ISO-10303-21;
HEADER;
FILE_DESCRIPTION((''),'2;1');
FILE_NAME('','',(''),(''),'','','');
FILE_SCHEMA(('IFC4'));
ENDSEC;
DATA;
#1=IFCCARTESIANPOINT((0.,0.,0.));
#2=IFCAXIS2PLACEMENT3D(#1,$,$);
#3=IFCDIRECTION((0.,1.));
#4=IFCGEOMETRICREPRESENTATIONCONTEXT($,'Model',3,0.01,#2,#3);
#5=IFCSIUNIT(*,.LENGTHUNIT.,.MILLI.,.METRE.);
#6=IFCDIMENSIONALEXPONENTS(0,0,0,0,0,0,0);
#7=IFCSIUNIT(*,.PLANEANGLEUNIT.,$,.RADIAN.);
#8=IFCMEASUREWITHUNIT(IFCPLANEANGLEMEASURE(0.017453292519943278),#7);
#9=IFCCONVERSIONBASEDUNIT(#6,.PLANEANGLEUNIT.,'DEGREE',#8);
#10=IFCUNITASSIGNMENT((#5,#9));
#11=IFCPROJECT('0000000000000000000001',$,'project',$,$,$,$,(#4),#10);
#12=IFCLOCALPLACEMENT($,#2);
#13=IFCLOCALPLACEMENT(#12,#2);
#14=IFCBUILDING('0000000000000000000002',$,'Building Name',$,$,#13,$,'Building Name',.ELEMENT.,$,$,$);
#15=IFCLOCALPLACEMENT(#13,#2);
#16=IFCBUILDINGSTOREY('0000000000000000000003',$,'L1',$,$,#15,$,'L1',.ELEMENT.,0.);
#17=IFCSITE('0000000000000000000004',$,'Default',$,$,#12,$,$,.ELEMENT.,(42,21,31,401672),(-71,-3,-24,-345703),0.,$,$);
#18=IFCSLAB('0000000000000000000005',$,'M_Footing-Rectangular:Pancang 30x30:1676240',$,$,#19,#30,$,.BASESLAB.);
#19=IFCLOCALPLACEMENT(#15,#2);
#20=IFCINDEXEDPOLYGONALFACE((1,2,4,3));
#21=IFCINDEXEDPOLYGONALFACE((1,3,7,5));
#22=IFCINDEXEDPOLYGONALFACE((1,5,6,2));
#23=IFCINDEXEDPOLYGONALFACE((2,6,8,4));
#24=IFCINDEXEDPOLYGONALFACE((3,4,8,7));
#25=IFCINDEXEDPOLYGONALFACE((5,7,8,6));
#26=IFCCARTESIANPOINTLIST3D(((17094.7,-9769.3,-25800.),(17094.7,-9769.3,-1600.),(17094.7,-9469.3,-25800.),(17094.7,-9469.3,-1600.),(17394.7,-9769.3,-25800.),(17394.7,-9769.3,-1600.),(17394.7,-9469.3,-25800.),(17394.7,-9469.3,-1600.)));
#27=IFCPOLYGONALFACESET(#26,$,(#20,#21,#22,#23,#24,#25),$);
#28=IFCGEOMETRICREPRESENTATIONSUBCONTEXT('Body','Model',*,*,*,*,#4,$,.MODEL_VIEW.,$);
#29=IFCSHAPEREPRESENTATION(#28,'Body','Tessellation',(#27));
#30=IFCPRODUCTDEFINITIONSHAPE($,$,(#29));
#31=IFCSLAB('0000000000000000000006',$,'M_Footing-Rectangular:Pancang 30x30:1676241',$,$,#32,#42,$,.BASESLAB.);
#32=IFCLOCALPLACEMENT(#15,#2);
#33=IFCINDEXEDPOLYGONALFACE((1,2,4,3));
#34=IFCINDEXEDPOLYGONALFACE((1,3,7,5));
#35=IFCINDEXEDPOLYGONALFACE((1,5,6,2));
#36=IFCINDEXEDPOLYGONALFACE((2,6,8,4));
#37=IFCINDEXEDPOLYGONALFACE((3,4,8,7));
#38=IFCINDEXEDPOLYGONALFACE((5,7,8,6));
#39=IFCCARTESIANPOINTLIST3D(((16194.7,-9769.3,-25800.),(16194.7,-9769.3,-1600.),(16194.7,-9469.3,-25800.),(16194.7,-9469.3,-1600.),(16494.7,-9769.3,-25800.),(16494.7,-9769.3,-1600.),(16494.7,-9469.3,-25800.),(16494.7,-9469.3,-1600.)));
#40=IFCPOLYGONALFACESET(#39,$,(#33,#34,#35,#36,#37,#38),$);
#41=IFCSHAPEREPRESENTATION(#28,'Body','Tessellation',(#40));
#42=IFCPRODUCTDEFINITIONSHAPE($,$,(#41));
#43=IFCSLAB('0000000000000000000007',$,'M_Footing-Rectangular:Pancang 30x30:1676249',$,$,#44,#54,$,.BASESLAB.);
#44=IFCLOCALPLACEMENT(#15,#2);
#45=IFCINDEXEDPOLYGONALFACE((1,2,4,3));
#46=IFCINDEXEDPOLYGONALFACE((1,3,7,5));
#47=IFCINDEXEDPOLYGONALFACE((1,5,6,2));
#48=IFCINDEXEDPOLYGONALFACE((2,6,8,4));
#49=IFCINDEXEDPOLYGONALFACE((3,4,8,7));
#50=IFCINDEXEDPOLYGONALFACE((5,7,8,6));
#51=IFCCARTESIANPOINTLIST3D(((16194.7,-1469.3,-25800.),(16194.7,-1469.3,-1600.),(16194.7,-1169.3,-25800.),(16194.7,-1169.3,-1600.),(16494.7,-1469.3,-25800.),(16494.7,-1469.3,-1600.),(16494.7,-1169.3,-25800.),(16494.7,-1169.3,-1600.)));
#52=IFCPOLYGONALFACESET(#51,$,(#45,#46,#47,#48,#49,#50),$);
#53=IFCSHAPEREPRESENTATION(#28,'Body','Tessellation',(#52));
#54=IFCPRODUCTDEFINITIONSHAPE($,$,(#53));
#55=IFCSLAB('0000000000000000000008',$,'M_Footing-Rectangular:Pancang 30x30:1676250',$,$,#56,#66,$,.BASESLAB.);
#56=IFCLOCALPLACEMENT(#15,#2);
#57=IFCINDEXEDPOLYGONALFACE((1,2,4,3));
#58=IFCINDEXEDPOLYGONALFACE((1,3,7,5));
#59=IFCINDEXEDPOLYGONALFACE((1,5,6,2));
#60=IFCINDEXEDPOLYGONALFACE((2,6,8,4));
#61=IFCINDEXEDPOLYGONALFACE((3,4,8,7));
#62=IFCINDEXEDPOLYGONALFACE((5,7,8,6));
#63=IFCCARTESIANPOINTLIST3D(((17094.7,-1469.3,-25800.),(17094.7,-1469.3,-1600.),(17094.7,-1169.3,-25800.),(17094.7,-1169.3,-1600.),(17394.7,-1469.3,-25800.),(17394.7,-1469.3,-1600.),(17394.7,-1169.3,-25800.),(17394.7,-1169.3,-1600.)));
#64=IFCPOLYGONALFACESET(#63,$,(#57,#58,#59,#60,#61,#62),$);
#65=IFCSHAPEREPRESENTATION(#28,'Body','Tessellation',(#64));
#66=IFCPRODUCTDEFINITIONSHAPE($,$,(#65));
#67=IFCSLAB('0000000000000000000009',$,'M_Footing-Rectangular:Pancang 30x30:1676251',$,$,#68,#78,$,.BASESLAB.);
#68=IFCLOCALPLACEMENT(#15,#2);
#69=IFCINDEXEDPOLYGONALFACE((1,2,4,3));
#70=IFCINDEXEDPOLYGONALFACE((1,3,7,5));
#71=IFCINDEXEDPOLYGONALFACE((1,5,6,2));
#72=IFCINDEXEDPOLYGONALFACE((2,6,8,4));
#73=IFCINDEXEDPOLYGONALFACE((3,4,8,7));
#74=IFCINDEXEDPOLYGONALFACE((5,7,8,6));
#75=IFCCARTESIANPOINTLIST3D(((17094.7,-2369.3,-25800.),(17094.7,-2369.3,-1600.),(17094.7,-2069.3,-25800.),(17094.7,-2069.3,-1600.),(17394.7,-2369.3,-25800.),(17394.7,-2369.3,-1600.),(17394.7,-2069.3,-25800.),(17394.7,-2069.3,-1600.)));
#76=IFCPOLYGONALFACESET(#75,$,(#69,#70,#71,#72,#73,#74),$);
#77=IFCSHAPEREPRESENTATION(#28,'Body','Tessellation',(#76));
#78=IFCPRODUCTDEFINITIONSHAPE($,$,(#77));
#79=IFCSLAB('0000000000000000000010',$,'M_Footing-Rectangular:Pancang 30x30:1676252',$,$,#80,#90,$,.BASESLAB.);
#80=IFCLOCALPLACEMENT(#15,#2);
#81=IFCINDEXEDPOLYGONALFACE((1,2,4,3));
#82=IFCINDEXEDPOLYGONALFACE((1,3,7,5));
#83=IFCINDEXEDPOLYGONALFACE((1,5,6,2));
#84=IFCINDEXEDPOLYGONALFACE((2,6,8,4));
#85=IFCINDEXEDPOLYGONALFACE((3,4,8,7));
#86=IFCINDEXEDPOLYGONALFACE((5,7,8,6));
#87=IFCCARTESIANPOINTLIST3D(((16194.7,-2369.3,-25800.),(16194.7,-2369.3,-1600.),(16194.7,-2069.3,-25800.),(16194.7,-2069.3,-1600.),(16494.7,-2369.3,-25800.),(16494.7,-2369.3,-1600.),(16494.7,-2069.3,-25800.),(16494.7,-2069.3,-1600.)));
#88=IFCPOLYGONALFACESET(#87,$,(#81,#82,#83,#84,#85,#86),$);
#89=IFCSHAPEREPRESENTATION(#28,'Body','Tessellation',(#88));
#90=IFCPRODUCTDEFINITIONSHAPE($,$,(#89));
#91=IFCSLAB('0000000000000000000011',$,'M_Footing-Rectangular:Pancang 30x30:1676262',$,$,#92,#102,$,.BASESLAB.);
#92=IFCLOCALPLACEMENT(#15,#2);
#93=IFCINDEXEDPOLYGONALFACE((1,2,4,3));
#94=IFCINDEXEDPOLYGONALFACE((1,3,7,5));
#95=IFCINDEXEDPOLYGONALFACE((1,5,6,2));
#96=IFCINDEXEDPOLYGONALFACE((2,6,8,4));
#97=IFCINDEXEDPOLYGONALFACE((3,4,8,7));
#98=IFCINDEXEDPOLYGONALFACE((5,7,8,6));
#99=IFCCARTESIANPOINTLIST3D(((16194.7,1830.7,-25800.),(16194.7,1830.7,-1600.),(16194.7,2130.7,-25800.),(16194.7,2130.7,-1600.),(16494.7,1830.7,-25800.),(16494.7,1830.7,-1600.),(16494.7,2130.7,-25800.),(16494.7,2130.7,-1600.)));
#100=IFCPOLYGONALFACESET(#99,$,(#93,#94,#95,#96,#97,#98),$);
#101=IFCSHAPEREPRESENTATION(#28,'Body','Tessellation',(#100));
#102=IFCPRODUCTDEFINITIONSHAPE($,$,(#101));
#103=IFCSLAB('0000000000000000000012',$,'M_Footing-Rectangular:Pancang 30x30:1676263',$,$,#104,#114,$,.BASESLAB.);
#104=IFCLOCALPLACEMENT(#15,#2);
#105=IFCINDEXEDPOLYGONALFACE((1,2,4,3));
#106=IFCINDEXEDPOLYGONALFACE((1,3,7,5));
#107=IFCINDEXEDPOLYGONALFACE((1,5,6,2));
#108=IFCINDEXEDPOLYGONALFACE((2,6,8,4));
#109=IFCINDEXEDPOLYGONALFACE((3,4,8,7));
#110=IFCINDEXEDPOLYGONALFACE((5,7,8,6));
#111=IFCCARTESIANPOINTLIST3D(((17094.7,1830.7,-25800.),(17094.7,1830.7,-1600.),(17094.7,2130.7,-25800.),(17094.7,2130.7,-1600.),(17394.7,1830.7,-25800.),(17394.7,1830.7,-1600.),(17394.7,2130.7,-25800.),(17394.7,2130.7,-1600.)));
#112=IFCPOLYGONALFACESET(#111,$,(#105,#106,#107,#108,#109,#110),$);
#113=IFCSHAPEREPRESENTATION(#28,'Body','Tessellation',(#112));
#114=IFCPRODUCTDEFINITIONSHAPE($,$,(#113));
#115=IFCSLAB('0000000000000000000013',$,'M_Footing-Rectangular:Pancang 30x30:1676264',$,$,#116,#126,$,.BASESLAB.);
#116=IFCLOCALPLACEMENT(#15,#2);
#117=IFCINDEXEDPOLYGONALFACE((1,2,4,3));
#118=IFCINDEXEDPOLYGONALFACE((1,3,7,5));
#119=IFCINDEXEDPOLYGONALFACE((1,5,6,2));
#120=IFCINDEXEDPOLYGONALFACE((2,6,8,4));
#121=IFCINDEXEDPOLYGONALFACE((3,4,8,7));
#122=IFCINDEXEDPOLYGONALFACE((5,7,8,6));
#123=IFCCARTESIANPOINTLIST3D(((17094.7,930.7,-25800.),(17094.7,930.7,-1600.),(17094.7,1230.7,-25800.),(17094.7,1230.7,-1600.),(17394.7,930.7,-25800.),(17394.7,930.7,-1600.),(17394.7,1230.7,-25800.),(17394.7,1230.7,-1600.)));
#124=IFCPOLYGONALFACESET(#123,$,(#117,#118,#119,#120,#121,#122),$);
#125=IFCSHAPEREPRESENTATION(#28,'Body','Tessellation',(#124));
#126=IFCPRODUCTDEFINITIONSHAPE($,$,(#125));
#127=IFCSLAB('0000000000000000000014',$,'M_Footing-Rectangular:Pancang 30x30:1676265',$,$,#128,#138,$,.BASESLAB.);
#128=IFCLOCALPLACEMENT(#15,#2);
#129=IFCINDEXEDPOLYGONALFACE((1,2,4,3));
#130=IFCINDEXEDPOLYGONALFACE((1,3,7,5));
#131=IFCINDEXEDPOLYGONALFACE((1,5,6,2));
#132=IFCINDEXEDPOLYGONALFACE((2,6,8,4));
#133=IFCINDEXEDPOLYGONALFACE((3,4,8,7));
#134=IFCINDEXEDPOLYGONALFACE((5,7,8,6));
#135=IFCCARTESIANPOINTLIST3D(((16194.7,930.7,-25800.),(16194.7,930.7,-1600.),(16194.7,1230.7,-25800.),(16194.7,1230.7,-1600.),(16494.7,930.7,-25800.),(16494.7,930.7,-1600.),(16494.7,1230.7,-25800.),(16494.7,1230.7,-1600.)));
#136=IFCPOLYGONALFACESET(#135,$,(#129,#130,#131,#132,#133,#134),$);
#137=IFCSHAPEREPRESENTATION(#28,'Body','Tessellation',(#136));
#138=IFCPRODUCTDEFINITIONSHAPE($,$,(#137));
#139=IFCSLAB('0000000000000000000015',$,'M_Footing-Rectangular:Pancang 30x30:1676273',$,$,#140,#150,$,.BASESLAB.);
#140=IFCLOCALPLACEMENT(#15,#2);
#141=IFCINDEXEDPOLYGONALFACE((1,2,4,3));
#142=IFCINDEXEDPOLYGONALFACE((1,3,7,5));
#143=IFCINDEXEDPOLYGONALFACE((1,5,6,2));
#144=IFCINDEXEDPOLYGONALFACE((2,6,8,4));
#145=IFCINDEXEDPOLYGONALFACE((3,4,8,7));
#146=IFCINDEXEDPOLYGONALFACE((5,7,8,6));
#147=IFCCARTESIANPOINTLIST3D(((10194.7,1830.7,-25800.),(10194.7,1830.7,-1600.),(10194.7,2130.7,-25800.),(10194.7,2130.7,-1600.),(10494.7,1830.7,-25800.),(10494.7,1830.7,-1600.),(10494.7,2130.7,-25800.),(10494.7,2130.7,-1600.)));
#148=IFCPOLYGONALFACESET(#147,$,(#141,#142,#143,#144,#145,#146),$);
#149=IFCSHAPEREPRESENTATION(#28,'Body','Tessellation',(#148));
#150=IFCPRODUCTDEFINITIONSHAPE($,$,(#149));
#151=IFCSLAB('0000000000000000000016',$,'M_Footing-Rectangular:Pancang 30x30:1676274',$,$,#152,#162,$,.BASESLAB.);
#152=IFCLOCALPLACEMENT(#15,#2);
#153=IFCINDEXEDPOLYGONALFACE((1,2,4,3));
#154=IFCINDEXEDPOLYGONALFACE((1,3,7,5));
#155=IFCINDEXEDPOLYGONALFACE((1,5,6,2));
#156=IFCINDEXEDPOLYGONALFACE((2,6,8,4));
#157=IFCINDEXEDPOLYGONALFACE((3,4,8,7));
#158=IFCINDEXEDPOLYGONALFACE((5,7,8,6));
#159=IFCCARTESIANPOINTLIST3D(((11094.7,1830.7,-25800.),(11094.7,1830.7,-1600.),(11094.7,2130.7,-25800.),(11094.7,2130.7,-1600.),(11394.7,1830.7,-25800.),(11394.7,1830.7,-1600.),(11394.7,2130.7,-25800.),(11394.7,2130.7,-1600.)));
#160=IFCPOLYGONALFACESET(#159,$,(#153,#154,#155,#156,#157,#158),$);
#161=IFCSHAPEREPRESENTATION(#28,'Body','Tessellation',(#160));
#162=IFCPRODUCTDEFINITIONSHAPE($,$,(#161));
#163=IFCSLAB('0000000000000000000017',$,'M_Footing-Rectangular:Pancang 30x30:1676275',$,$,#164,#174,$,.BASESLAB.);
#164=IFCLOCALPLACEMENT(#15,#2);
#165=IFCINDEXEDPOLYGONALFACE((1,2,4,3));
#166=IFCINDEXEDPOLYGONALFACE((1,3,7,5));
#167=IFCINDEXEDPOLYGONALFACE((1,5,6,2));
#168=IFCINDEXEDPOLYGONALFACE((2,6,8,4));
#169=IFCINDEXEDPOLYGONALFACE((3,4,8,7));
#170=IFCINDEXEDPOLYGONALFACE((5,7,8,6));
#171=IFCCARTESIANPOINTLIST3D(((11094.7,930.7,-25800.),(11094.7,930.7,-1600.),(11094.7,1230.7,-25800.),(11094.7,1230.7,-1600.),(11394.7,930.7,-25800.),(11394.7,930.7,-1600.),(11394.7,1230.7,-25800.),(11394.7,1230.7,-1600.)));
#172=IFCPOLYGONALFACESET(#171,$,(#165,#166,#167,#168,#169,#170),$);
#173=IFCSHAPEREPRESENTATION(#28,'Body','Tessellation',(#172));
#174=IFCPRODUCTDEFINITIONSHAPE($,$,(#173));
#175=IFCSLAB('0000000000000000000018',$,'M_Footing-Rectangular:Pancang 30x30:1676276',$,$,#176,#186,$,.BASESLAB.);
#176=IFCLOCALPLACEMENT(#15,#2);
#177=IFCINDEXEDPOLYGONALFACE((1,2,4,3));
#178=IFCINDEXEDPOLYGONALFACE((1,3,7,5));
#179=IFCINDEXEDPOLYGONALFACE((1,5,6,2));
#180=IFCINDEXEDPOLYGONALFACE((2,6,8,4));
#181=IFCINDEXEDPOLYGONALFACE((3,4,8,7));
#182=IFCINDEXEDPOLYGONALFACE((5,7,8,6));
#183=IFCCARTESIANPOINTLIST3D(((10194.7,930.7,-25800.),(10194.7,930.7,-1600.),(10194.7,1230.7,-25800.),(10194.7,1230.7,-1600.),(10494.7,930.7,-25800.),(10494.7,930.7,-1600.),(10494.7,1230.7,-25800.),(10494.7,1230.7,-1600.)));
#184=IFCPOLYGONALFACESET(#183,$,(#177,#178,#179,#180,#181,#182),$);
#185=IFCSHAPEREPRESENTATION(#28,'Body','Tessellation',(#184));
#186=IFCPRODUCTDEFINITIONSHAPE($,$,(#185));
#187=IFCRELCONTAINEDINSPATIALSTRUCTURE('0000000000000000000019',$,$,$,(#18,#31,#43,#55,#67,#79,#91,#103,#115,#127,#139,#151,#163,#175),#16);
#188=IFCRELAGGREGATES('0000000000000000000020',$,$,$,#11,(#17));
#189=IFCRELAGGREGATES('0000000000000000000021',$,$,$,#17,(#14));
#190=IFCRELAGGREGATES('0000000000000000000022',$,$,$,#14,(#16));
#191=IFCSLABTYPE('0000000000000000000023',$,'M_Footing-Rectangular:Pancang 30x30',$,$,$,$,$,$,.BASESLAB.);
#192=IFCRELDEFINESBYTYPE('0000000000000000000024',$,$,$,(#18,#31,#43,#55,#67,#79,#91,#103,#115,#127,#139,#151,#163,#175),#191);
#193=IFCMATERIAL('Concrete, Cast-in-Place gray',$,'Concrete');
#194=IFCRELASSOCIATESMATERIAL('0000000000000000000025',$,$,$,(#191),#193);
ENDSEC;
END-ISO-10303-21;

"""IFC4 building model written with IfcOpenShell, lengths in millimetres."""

from ifc_helpers import new_model, entity, si_unit, converted_unit, direction, frame, origin, place, context, subcontext, project, spatial, indexed_curve, outline, extrude, material, type_object, element, save


model = new_model("IFC4")

# Units and contexts
model_context = context("Model", 3, precision=0.01, world=origin(), true_north=direction((0.0, 1.0)))
body_context = subcontext(model_context, "Body", "Model", "MODEL_VIEW")
ifc_project = project(units=[si_unit("LENGTHUNIT", "METRE", prefix="MILLI"), converted_unit("PLANEANGLEUNIT", "DEGREE", entity("IfcPlaneAngleMeasure", 0.017453292519943278), si_unit("PLANEANGLEUNIT", "RADIAN"), dimensions=[0, 0, 0, 0, 0, 0, 0])], contexts=[model_context])

# Site, building, storey
site_placement = place(None, origin())
site = spatial("IfcSite", under=ifc_project, at=site_placement, Name="Default", CompositionType="ELEMENT", RefLatitude=(42, 21, 31, 401672), RefLongitude=(-71, -3, -24, -345703), RefElevation=0.0)
building_placement = place(site_placement, origin())
building = spatial("IfcBuilding", under=site, at=building_placement, Name="Building Name", LongName="Building Name", CompositionType="ELEMENT")
storey_placement = place(building_placement, origin())
storey = spatial("IfcBuildingStorey", under=building, at=storey_placement, Name="L1", LongName="L1", CompositionType="ELEMENT", Elevation=0.0)

# Slabs
ifc_material = material(Name="Concrete, Cast-in-Place gray", Category="Concrete")
slab_type = type_object("IfcSlabType", Name="M_Footing-Rectangular:Pancang 30x30", PredefinedType="BASESLAB", material=ifc_material)
slab_1_placement = place(storey_placement, origin())
element("IfcSlab", 1, at=slab_1_placement, inside=storey, type_object=slab_type, Name="M_Footing-Rectangular:Pancang 30x30:1676240", PredefinedType="BASESLAB", context=body_context, shape_type="SweptSolid", body=[
    extrude(outline(indexed_curve([(-150.0, -150.0), (150.0, -150.0), (150.0, 150.0), (-150.0, 150.0), (-150.0, -150.0)], self_intersect=False)), frame((17244.7, -9619.3, -25800.0), z_axis=(0.0, 0.0, 1.0), x_axis=(-1.0, 0.0, 0.0)), (0.0, 0.0, 1.0), 24200.0),
])
slab_2_placement = place(storey_placement, origin())
element("IfcSlab", 2, at=slab_2_placement, inside=storey, type_object=slab_type, Name="M_Footing-Rectangular:Pancang 30x30:1676241", PredefinedType="BASESLAB", context=body_context, shape_type="SweptSolid", body=[
    extrude(outline(indexed_curve([(-150.0, -150.0), (150.0, -150.0), (150.0, 150.0), (-150.0, 150.0), (-150.0, -150.0)], self_intersect=False)), frame((16344.7, -9619.3, -25800.0), z_axis=(0.0, 0.0, 1.0), x_axis=(-1.0, 0.0, 0.0)), (0.0, 0.0, 1.0), 24200.0),
])
slab_3_placement = place(storey_placement, origin())
element("IfcSlab", 3, at=slab_3_placement, inside=storey, type_object=slab_type, Name="M_Footing-Rectangular:Pancang 30x30:1676249", PredefinedType="BASESLAB", context=body_context, shape_type="SweptSolid", body=[
    extrude(outline(indexed_curve([(-150.0, -150.0), (150.0, -150.0), (150.0, 150.0), (-150.0, 150.0), (-150.0, -150.0)], self_intersect=False)), frame((16344.7, -1319.3, -25800.0), z_axis=(0.0, 0.0, 1.0), x_axis=(-1.0, 0.0, 0.0)), (0.0, 0.0, 1.0), 24200.0),
])
slab_4_placement = place(storey_placement, origin())
element("IfcSlab", 4, at=slab_4_placement, inside=storey, type_object=slab_type, Name="M_Footing-Rectangular:Pancang 30x30:1676250", PredefinedType="BASESLAB", context=body_context, shape_type="SweptSolid", body=[
    extrude(outline(indexed_curve([(-150.0, -150.0), (150.0, -150.0), (150.0, 150.0), (-150.0, 150.0), (-150.0, -150.0)], self_intersect=False)), frame((17244.7, -1319.3, -25800.0), z_axis=(0.0, 0.0, 1.0), x_axis=(-1.0, 0.0, 0.0)), (0.0, 0.0, 1.0), 24200.0),
])
slab_5_placement = place(storey_placement, origin())
element("IfcSlab", 5, at=slab_5_placement, inside=storey, type_object=slab_type, Name="M_Footing-Rectangular:Pancang 30x30:1676251", PredefinedType="BASESLAB", context=body_context, shape_type="SweptSolid", body=[
    extrude(outline(indexed_curve([(-150.0, -150.0), (150.0, -150.0), (150.0, 150.0), (-150.0, 150.0), (-150.0, -150.0)], self_intersect=False)), frame((17244.7, -2219.3, -25800.0), z_axis=(0.0, 0.0, 1.0), x_axis=(-1.0, 0.0, 0.0)), (0.0, 0.0, 1.0), 24200.0),
])
slab_6_placement = place(storey_placement, origin())
element("IfcSlab", 6, at=slab_6_placement, inside=storey, type_object=slab_type, Name="M_Footing-Rectangular:Pancang 30x30:1676252", PredefinedType="BASESLAB", context=body_context, shape_type="SweptSolid", body=[
    extrude(outline(indexed_curve([(-150.0, -150.0), (150.0, -150.0), (150.0, 150.0), (-150.0, 150.0), (-150.0, -150.0)], self_intersect=False)), frame((16344.7, -2219.3, -25800.0), z_axis=(0.0, 0.0, 1.0), x_axis=(-1.0, 0.0, 0.0)), (0.0, 0.0, 1.0), 24200.0),
])
slab_7_placement = place(storey_placement, origin())
element("IfcSlab", 7, at=slab_7_placement, inside=storey, type_object=slab_type, Name="M_Footing-Rectangular:Pancang 30x30:1676262", PredefinedType="BASESLAB", context=body_context, shape_type="SweptSolid", body=[
    extrude(outline(indexed_curve([(-150.0, -150.0), (150.0, -150.0), (150.0, 150.0), (-150.0, 150.0), (-150.0, -150.0)], self_intersect=False)), frame((16344.7, 1980.7, -25800.0), z_axis=(0.0, 0.0, 1.0), x_axis=(-1.0, 0.0, 0.0)), (0.0, 0.0, 1.0), 24200.0),
])
slab_8_placement = place(storey_placement, origin())
element("IfcSlab", 8, at=slab_8_placement, inside=storey, type_object=slab_type, Name="M_Footing-Rectangular:Pancang 30x30:1676263", PredefinedType="BASESLAB", context=body_context, shape_type="SweptSolid", body=[
    extrude(outline(indexed_curve([(-150.0, -150.0), (150.0, -150.0), (150.0, 150.0), (-150.0, 150.0), (-150.0, -150.0)], self_intersect=False)), frame((17244.7, 1980.7, -25800.0), z_axis=(0.0, 0.0, 1.0), x_axis=(-1.0, 0.0, 0.0)), (0.0, 0.0, 1.0), 24200.0),
])
slab_9_placement = place(storey_placement, origin())
element("IfcSlab", 9, at=slab_9_placement, inside=storey, type_object=slab_type, Name="M_Footing-Rectangular:Pancang 30x30:1676264", PredefinedType="BASESLAB", context=body_context, shape_type="SweptSolid", body=[
    extrude(outline(indexed_curve([(-150.0, -150.0), (150.0, -150.0), (150.0, 150.0), (-150.0, 150.0), (-150.0, -150.0)], self_intersect=False)), frame((17244.7, 1080.7, -25800.0), z_axis=(0.0, 0.0, 1.0), x_axis=(-1.0, 0.0, 0.0)), (0.0, 0.0, 1.0), 24200.0),
])
slab_10_placement = place(storey_placement, origin())
element("IfcSlab", 10, at=slab_10_placement, inside=storey, type_object=slab_type, Name="M_Footing-Rectangular:Pancang 30x30:1676265", PredefinedType="BASESLAB", context=body_context, shape_type="SweptSolid", body=[
    extrude(outline(indexed_curve([(-150.0, -150.0), (150.0, -150.0), (150.0, 150.0), (-150.0, 150.0), (-150.0, -150.0)], self_intersect=False)), frame((16344.7, 1080.7, -25800.0), z_axis=(0.0, 0.0, 1.0), x_axis=(-1.0, 0.0, 0.0)), (0.0, 0.0, 1.0), 24200.0),
])
slab_11_placement = place(storey_placement, origin())
element("IfcSlab", 11, at=slab_11_placement, inside=storey, type_object=slab_type, Name="M_Footing-Rectangular:Pancang 30x30:1676273", PredefinedType="BASESLAB", context=body_context, shape_type="SweptSolid", body=[
    extrude(outline(indexed_curve([(-150.0, -150.0), (150.0, -150.0), (150.0, 150.0), (-150.0, 150.0), (-150.0, -150.0)], self_intersect=False)), frame((10344.7, 1980.7, -25800.0), z_axis=(0.0, 0.0, 1.0), x_axis=(-1.0, 0.0, 0.0)), (0.0, 0.0, 1.0), 24200.0),
])
slab_12_placement = place(storey_placement, origin())
element("IfcSlab", 12, at=slab_12_placement, inside=storey, type_object=slab_type, Name="M_Footing-Rectangular:Pancang 30x30:1676274", PredefinedType="BASESLAB", context=body_context, shape_type="SweptSolid", body=[
    extrude(outline(indexed_curve([(-150.0, -150.0), (150.0, -150.0), (150.0, 150.0), (-150.0, 150.0), (-150.0, -150.0)], self_intersect=False)), frame((11244.7, 1980.7, -25800.0), z_axis=(0.0, 0.0, 1.0), x_axis=(-1.0, 0.0, 0.0)), (0.0, 0.0, 1.0), 24200.0),
])
slab_13_placement = place(storey_placement, origin())
element("IfcSlab", 13, at=slab_13_placement, inside=storey, type_object=slab_type, Name="M_Footing-Rectangular:Pancang 30x30:1676275", PredefinedType="BASESLAB", context=body_context, shape_type="SweptSolid", body=[
    extrude(outline(indexed_curve([(-150.0, -150.0), (150.0, -150.0), (150.0, 150.0), (-150.0, 150.0), (-150.0, -150.0)], self_intersect=False)), frame((11244.7, 1080.7, -25800.0), z_axis=(0.0, 0.0, 1.0), x_axis=(-1.0, 0.0, 0.0)), (0.0, 0.0, 1.0), 24200.0),
])
slab_14_placement = place(storey_placement, origin())
element("IfcSlab", 14, at=slab_14_placement, inside=storey, type_object=slab_type, Name="M_Footing-Rectangular:Pancang 30x30:1676276", PredefinedType="BASESLAB", context=body_context, shape_type="SweptSolid", body=[
    extrude(outline(indexed_curve([(-150.0, -150.0), (150.0, -150.0), (150.0, 150.0), (-150.0, 150.0), (-150.0, -150.0)], self_intersect=False)), frame((10344.7, 1080.7, -25800.0), z_axis=(0.0, 0.0, 1.0), x_axis=(-1.0, 0.0, 0.0)), (0.0, 0.0, 1.0), 24200.0),
])

save(model, "model.ifc")
